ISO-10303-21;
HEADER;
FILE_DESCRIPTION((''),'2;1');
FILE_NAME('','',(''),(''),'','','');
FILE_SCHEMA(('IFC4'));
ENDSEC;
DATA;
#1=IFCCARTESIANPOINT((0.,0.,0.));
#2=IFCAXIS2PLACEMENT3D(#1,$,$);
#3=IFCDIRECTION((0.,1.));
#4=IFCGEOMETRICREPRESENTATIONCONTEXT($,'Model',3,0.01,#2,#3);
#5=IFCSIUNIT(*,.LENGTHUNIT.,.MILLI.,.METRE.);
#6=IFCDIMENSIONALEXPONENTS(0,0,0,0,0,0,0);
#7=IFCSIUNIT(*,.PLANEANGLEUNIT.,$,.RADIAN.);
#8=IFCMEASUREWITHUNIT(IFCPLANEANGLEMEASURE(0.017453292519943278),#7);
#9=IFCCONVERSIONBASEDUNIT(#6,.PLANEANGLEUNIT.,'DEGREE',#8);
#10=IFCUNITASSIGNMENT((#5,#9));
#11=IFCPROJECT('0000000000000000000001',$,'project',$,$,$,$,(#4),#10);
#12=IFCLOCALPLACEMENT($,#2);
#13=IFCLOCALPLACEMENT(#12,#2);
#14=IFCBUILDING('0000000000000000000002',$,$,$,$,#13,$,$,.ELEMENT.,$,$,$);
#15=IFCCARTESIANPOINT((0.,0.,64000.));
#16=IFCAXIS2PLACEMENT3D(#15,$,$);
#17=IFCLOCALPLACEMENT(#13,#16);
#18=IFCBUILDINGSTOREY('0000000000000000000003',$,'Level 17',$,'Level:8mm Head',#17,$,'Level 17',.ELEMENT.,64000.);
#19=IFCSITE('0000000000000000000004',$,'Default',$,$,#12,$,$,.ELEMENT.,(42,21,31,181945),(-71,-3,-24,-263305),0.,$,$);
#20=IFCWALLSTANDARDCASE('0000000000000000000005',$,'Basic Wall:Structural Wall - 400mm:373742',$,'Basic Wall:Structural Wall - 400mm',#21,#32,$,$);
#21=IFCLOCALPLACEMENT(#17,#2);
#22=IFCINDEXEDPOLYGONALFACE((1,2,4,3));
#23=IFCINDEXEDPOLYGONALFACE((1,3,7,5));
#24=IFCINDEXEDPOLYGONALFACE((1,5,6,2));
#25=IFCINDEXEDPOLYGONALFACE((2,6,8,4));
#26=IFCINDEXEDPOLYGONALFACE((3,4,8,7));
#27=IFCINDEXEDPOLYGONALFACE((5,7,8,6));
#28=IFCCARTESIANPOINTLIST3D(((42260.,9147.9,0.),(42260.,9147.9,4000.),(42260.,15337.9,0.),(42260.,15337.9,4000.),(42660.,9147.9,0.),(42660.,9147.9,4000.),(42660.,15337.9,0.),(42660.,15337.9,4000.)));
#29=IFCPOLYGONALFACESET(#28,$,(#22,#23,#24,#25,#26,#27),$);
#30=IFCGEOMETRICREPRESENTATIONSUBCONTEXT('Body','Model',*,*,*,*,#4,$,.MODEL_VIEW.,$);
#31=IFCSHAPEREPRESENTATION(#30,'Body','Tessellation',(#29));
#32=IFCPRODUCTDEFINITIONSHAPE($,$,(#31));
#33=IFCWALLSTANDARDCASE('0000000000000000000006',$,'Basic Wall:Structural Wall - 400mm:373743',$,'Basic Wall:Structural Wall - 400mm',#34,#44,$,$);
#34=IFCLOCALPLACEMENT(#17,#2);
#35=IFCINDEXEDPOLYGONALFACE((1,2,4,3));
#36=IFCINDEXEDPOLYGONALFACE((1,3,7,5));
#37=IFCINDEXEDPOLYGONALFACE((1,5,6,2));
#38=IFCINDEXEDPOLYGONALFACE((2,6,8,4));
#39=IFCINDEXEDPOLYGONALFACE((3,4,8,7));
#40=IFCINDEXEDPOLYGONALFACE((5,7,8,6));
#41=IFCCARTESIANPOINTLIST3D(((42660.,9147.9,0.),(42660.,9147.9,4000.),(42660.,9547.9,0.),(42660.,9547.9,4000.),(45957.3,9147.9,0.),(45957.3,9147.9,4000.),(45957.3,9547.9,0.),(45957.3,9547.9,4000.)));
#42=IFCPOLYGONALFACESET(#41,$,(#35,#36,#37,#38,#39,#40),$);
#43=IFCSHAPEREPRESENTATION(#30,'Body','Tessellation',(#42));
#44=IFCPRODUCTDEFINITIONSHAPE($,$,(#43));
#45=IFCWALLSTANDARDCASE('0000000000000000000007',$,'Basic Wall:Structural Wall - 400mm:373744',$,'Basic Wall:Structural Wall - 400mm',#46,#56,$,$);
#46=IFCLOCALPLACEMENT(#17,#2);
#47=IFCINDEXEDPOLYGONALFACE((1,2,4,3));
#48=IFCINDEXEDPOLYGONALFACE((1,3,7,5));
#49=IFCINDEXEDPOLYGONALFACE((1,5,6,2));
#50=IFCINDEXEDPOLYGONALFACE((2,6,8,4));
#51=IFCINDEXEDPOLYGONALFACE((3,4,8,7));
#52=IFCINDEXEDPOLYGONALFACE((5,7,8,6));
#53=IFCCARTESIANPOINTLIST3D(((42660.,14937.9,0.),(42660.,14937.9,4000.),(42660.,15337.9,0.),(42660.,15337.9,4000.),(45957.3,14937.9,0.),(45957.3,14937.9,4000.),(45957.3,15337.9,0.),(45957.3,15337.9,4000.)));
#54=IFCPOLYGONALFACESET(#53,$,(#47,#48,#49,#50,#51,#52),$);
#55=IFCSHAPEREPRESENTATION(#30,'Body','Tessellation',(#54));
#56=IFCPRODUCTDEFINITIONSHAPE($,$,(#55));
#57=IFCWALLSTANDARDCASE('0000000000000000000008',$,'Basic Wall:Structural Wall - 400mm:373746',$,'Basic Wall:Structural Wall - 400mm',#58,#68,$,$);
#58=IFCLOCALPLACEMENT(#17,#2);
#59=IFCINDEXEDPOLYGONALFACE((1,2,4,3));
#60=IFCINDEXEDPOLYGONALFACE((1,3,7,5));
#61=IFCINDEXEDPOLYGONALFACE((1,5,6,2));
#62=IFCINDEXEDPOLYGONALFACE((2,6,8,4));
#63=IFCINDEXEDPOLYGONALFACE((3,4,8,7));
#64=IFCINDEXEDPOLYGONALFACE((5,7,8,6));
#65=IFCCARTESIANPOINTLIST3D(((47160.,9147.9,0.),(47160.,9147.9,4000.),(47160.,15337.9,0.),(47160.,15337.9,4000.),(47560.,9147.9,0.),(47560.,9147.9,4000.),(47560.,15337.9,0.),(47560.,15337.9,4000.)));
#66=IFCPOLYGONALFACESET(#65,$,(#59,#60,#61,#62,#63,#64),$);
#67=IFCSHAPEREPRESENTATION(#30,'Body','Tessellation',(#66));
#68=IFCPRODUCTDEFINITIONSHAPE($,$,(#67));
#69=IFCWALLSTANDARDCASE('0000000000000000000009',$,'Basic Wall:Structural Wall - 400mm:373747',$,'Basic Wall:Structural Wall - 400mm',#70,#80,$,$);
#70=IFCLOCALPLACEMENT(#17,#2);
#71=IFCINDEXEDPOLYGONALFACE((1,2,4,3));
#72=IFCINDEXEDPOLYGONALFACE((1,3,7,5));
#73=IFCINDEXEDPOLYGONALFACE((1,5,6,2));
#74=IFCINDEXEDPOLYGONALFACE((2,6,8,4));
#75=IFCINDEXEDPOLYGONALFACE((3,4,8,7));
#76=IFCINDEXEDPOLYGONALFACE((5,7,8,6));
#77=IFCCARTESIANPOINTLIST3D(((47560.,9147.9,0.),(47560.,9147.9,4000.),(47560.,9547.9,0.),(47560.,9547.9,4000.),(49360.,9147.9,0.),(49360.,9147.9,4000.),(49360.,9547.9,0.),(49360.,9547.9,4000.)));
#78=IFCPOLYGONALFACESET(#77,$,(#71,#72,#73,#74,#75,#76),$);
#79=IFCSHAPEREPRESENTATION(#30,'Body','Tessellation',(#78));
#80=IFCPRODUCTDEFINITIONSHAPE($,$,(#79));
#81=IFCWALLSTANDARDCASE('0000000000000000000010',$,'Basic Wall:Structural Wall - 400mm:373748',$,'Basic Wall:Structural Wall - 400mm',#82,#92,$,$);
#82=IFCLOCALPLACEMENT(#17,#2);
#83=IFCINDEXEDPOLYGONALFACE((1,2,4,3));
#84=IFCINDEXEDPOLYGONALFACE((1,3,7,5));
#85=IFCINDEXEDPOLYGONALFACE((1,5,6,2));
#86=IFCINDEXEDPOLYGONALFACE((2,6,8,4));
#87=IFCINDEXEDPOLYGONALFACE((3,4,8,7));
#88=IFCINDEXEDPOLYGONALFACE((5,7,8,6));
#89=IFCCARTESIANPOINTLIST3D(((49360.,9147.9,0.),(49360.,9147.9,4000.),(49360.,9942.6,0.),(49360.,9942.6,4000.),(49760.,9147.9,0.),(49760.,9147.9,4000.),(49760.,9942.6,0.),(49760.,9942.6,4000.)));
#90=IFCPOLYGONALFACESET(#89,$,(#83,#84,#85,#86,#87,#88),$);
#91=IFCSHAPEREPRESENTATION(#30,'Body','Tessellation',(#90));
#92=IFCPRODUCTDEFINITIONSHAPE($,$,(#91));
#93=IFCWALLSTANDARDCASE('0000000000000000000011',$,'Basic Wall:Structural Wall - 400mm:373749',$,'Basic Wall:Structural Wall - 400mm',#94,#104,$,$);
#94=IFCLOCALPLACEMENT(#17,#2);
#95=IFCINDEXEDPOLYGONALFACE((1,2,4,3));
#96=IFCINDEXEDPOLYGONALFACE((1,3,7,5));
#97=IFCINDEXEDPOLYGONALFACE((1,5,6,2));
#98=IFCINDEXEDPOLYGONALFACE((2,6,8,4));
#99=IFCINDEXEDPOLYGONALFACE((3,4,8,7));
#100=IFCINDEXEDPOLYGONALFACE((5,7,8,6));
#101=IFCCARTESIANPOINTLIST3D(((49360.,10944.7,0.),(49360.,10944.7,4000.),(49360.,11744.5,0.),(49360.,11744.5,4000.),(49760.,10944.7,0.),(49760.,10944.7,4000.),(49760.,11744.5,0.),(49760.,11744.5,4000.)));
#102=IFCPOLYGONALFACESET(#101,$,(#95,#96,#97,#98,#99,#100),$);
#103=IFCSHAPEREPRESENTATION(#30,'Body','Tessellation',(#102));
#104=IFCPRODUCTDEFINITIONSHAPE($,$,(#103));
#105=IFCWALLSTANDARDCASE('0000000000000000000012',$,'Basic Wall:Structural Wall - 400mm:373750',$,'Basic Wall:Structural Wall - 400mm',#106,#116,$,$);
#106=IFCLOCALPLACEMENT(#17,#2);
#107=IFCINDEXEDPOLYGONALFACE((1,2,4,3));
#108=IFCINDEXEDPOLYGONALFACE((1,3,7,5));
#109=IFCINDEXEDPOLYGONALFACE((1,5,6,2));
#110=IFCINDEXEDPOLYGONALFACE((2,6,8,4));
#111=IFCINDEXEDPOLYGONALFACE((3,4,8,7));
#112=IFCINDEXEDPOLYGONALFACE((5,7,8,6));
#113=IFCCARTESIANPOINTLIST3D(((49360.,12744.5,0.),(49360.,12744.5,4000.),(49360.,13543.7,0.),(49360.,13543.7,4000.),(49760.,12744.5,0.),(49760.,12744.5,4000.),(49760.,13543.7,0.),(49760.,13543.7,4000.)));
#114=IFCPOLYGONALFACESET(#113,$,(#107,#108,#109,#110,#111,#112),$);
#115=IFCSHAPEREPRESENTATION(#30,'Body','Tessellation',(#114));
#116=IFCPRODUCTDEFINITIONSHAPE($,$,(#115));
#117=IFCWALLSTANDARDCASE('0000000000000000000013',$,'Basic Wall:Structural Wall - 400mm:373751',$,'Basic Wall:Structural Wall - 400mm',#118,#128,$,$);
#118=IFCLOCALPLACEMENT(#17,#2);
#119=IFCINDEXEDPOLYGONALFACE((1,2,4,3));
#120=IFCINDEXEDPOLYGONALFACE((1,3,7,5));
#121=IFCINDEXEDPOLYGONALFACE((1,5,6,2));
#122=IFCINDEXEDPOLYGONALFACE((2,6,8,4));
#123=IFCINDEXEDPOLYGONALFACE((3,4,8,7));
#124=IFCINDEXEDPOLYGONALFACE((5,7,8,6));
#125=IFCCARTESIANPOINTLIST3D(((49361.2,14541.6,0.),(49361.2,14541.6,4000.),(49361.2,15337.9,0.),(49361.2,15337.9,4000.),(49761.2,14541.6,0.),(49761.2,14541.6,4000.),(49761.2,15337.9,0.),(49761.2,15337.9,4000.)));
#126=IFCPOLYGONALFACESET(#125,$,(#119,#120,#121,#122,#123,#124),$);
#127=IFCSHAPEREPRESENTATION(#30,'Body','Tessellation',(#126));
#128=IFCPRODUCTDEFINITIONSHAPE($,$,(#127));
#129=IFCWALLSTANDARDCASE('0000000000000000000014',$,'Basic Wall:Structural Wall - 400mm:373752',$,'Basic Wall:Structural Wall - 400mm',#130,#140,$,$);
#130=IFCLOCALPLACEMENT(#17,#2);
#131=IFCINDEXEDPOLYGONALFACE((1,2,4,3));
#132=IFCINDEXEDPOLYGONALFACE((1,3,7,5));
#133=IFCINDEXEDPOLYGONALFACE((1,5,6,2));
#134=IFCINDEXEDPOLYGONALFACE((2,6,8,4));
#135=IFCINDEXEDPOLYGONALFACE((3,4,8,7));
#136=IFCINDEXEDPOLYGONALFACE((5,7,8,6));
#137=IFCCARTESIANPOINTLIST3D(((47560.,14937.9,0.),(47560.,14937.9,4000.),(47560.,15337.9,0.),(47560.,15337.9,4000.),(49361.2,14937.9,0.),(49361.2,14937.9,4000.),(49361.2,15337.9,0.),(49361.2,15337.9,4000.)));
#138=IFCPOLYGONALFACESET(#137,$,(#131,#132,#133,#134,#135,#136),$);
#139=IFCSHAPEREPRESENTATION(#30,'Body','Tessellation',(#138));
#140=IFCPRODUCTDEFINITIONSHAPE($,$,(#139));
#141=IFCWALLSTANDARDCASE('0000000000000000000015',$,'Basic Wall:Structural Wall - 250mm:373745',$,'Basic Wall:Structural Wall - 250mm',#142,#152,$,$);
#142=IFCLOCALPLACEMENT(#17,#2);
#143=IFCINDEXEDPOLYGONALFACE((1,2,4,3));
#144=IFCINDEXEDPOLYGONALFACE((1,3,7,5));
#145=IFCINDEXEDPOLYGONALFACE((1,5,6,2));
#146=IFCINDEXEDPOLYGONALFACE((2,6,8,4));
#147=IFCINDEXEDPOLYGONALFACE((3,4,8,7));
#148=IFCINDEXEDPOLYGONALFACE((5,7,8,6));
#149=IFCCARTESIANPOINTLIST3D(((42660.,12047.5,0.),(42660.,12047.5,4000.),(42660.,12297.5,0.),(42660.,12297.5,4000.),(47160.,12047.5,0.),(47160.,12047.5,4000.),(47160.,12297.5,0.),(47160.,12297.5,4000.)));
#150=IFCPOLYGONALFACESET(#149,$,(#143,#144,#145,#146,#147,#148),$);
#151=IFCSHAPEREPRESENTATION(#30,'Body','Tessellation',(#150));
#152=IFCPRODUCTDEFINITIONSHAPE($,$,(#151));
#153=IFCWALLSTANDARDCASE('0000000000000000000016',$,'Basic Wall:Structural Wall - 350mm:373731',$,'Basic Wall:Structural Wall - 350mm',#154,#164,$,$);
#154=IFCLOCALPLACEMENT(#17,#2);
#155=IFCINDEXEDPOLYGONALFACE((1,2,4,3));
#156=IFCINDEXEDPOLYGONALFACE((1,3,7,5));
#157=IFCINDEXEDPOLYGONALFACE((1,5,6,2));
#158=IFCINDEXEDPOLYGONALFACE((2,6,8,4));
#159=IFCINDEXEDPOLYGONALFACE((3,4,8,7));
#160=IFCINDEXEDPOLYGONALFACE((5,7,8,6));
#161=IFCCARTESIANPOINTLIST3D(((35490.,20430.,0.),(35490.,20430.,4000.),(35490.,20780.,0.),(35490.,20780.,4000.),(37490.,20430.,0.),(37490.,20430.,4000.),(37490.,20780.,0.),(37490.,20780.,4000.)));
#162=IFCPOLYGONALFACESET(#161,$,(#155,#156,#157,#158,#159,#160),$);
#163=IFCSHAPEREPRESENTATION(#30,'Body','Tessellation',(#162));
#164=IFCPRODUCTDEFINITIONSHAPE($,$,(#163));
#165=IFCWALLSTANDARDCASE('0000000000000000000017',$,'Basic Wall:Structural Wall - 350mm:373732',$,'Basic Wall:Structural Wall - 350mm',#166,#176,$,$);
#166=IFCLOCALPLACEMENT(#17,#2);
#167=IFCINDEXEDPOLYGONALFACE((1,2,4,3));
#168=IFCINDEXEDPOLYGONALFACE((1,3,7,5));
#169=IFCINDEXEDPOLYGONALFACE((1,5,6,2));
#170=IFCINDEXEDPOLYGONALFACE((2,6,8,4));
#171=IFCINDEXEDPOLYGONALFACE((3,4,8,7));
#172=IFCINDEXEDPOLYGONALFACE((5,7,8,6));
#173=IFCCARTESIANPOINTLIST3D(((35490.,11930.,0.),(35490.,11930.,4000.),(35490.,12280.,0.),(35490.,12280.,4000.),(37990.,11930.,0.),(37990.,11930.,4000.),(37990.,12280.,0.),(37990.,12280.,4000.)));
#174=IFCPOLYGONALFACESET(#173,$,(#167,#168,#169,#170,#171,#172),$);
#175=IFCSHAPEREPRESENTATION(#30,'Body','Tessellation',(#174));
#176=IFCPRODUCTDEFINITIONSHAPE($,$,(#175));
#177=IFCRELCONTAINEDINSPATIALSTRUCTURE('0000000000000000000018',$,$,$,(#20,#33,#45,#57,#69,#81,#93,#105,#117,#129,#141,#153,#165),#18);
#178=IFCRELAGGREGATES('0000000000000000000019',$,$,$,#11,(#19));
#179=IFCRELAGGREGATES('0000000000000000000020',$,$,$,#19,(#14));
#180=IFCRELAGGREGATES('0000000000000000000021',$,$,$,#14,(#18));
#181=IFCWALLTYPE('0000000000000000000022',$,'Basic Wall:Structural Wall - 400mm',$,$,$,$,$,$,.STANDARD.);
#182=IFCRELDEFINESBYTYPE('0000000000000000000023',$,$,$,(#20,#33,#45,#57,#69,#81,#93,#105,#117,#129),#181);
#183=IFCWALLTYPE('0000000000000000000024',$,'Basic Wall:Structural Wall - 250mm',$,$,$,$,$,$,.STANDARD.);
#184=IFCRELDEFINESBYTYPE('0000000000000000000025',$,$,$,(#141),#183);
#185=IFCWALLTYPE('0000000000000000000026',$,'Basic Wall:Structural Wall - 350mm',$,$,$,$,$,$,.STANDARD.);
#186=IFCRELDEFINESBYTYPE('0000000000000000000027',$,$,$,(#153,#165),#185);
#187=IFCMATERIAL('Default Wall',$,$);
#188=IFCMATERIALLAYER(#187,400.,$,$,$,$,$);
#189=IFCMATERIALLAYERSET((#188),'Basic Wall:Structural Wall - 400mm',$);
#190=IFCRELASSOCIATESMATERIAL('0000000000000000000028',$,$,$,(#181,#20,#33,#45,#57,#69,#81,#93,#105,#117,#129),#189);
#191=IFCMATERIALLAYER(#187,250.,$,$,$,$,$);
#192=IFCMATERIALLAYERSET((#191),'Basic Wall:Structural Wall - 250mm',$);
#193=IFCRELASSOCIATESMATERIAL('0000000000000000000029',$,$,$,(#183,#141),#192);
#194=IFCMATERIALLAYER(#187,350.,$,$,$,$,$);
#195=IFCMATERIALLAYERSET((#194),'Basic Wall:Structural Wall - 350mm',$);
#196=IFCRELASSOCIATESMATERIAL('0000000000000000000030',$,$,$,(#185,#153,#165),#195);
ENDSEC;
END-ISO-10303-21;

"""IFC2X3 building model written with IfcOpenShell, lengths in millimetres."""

from ifc_helpers import new_model, entity, si_unit, converted_unit, direction, frame, frame_2d, origin, place, context, subcontext, project, spatial, rectangle, extrude, material, layer, layer_set, layer_usage, type_object, element, save


model = new_model("IFC2X3")

# Units and contexts
model_context = context("Model", 3, precision=0.01, world=origin(), true_north=direction((0.0, 1.0)))
body_context = subcontext(model_context, "Body", "Model", "MODEL_VIEW")
ifc_project = project(units=[si_unit("LENGTHUNIT", "METRE", prefix="MILLI"), converted_unit("PLANEANGLEUNIT", "DEGREE", entity("IfcPlaneAngleMeasure", 0.017453292519943278), si_unit("PLANEANGLEUNIT", "RADIAN"), dimensions=[0, 0, 0, 0, 0, 0, 0])], contexts=[model_context])

# Site, building, storey
site_placement = place(None, origin())
site = spatial("IfcSite", under=ifc_project, at=site_placement, Name="Default", CompositionType="ELEMENT", RefLatitude=(42, 21, 31, 181945), RefLongitude=(-71, -3, -24, -263305), RefElevation=0.0)
building_placement = place(site_placement, origin())
building = spatial("IfcBuilding", under=site, at=building_placement, CompositionType="ELEMENT")
storey_placement = place(building_placement, frame((0.0, 0.0, 64000.0)))
storey = spatial("IfcBuildingStorey", under=building, at=storey_placement, Name="Level 17", ObjectType="Level:8mm Head", LongName="Level 17", CompositionType="ELEMENT", Elevation=64000.0)

# Walls
ifc_material_1 = material(Name="Default Wall")
ifc_layer_1 = layer(ifc_material_1, 400.0)
ifc_layer_set_1 = layer_set([ifc_layer_1], Name="Basic Wall:Structural Wall - 400mm")
ifc_layer_usage_1 = layer_usage(ifc_layer_set_1, "AXIS2", "POSITIVE", -200.0)
wall_type_1 = type_object("IfcWallType", Name="Basic Wall:Structural Wall - 400mm", PredefinedType="STANDARD", material=ifc_layer_set_1)
wall_1_placement = place(storey_placement, frame((42460.0, 15337.9, 0.0), z_axis=(0.0, 0.0, 1.0), x_axis=(0.0, -1.0, 0.0)))
element("IfcWallStandardCase", 1, at=wall_1_placement, inside=storey, type_object=wall_type_1, material=ifc_layer_usage_1, Name="Basic Wall:Structural Wall - 400mm:373742", ObjectType="Basic Wall:Structural Wall - 400mm", context=body_context, shape_type="SweptSolid", body=[
    extrude(rectangle(XDim=6190.0, YDim=400.0, at=frame_2d((3095.0, 0.0), x_axis=(-1.0, 0.0))), origin(), (0.0, 0.0, 1.0), 4000.0),
])
ifc_layer_usage_2 = layer_usage(ifc_layer_set_1, "AXIS2", "POSITIVE", -200.0)
wall_2_placement = place(storey_placement, frame((42660.0, 9347.9, 0.0)))
element("IfcWallStandardCase", 2, at=wall_2_placement, inside=storey, type_object=wall_type_1, material=ifc_layer_usage_2, Name="Basic Wall:Structural Wall - 400mm:373743", ObjectType="Basic Wall:Structural Wall - 400mm", context=body_context, shape_type="SweptSolid", body=[
    extrude(rectangle(XDim=3297.3, YDim=400.0, at=frame_2d((1648.6, 0.0), x_axis=(-1.0, 0.0))), origin(), (0.0, 0.0, 1.0), 4000.0),
])
ifc_layer_usage_3 = layer_usage(ifc_layer_set_1, "AXIS2", "POSITIVE", -200.0)
wall_3_placement = place(storey_placement, frame((45957.3, 15137.9, 0.0), z_axis=(0.0, 0.0, 1.0), x_axis=(-1.0, 0.0, 0.0)))
element("IfcWallStandardCase", 3, at=wall_3_placement, inside=storey, type_object=wall_type_1, material=ifc_layer_usage_3, Name="Basic Wall:Structural Wall - 400mm:373744", ObjectType="Basic Wall:Structural Wall - 400mm", context=body_context, shape_type="SweptSolid", body=[
    extrude(rectangle(XDim=3297.3, YDim=400.0, at=frame_2d((1648.6, 0.0), x_axis=(-1.0, 0.0))), origin(), (0.0, 0.0, 1.0), 4000.0),
])
ifc_layer_usage_4 = layer_usage(ifc_layer_set_1, "AXIS2", "POSITIVE", -200.0)
wall_4_placement = place(storey_placement, frame((47360.0, 15337.9, 0.0), z_axis=(0.0, 0.0, 1.0), x_axis=(0.0, -1.0, 0.0)))
element("IfcWallStandardCase", 4, at=wall_4_placement, inside=storey, type_object=wall_type_1, material=ifc_layer_usage_4, Name="Basic Wall:Structural Wall - 400mm:373746", ObjectType="Basic Wall:Structural Wall - 400mm", context=body_context, shape_type="SweptSolid", body=[
    extrude(rectangle(XDim=6190.0, YDim=400.0, at=frame_2d((3095.0, 0.0), x_axis=(-1.0, 0.0))), origin(), (0.0, 0.0, 1.0), 4000.0),
])
ifc_layer_usage_5 = layer_usage(ifc_layer_set_1, "AXIS2", "POSITIVE", -200.0)
wall_5_placement = place(storey_placement, frame((47560.0, 9347.9, 0.0)))
element("IfcWallStandardCase", 5, at=wall_5_placement, inside=storey, type_object=wall_type_1, material=ifc_layer_usage_5, Name="Basic Wall:Structural Wall - 400mm:373747", ObjectType="Basic Wall:Structural Wall - 400mm", context=body_context, shape_type="SweptSolid", body=[
    extrude(rectangle(XDim=1800.0, YDim=400.0, at=frame_2d((900.0, 0.0), x_axis=(-1.0, 0.0))), origin(), (0.0, 0.0, 1.0), 4000.0),
])
ifc_layer_usage_6 = layer_usage(ifc_layer_set_1, "AXIS2", "NEGATIVE", 200.0)
wall_6_placement = place(storey_placement, frame((49560.0, 9147.9, 0.0), z_axis=(0.0, 0.0, 1.0), x_axis=(0.0, 1.0, 0.0)))
element("IfcWallStandardCase", 6, at=wall_6_placement, inside=storey, type_object=wall_type_1, material=ifc_layer_usage_6, Name="Basic Wall:Structural Wall - 400mm:373748", ObjectType="Basic Wall:Structural Wall - 400mm", context=body_context, shape_type="SweptSolid", body=[
    extrude(rectangle(XDim=794.7, YDim=400.0, at=frame_2d((397.3, 0.0), x_axis=(-1.0, 0.0))), origin(), (0.0, 0.0, 1.0), 4000.0),
])
ifc_layer_usage_7 = layer_usage(ifc_layer_set_1, "AXIS2", "POSITIVE", -200.0)
wall_7_placement = place(storey_placement, frame((49560.0, 10944.7, 0.0), z_axis=(0.0, 0.0, 1.0), x_axis=(0.0, 1.0, 0.0)))
element("IfcWallStandardCase", 7, at=wall_7_placement, inside=storey, type_object=wall_type_1, material=ifc_layer_usage_7, Name="Basic Wall:Structural Wall - 400mm:373749", ObjectType="Basic Wall:Structural Wall - 400mm", context=body_context, shape_type="SweptSolid", body=[
    extrude(rectangle(XDim=799.8, YDim=400.0, at=frame_2d((399.9, 0.0), x_axis=(-1.0, 0.0))), origin(), (0.0, 0.0, 1.0), 4000.0),
])
ifc_layer_usage_8 = layer_usage(ifc_layer_set_1, "AXIS2", "POSITIVE", -200.0)
wall_8_placement = place(storey_placement, frame((49560.0, 12744.5, 0.0), z_axis=(0.0, 0.0, 1.0), x_axis=(0.0, 1.0, 0.0)))
element("IfcWallStandardCase", 8, at=wall_8_placement, inside=storey, type_object=wall_type_1, material=ifc_layer_usage_8, Name="Basic Wall:Structural Wall - 400mm:373750", ObjectType="Basic Wall:Structural Wall - 400mm", context=body_context, shape_type="SweptSolid", body=[
    extrude(rectangle(XDim=799.2, YDim=400.0, at=frame_2d((399.6, 0.0), x_axis=(-1.0, 0.0))), origin(), (0.0, 0.0, 1.0), 4000.0),
])
ifc_layer_usage_9 = layer_usage(ifc_layer_set_1, "AXIS2", "POSITIVE", -200.0)
wall_9_placement = place(storey_placement, frame((49561.2, 14541.6, 0.0), z_axis=(0.0, 0.0, 1.0), x_axis=(0.0, 1.0, 0.0)))
element("IfcWallStandardCase", 9, at=wall_9_placement, inside=storey, type_object=wall_type_1, material=ifc_layer_usage_9, Name="Basic Wall:Structural Wall - 400mm:373751", ObjectType="Basic Wall:Structural Wall - 400mm", context=body_context, shape_type="SweptSolid", body=[
    extrude(rectangle(XDim=796.3, YDim=400.0, at=frame_2d((398.2, 0.0), x_axis=(-1.0, 0.0))), origin(), (0.0, 0.0, 1.0), 4000.0),
])
ifc_layer_usage_10 = layer_usage(ifc_layer_set_1, "AXIS2", "POSITIVE", -200.0)
wall_10_placement = place(storey_placement, frame((49361.2, 15137.9, 0.0), z_axis=(0.0, 0.0, 1.0), x_axis=(-1.0, 0.0, 0.0)))
element("IfcWallStandardCase", 10, at=wall_10_placement, inside=storey, type_object=wall_type_1, material=ifc_layer_usage_10, Name="Basic Wall:Structural Wall - 400mm:373752", ObjectType="Basic Wall:Structural Wall - 400mm", context=body_context, shape_type="SweptSolid", body=[
    extrude(rectangle(XDim=1801.2, YDim=400.0, at=frame_2d((900.6, 0.0), x_axis=(-1.0, 0.0))), origin(), (0.0, 0.0, 1.0), 4000.0),
])
ifc_layer_2 = layer(ifc_material_1, 250.0)
ifc_layer_set_2 = layer_set([ifc_layer_2], Name="Basic Wall:Structural Wall - 250mm")
ifc_layer_usage_11 = layer_usage(ifc_layer_set_2, "AXIS2", "NEGATIVE", 125.0)
wall_type_2 = type_object("IfcWallType", Name="Basic Wall:Structural Wall - 250mm", PredefinedType="STANDARD", material=ifc_layer_set_2)
wall_11_placement = place(storey_placement, frame((42660.0, 12172.5, 0.0)))
element("IfcWallStandardCase", 11, at=wall_11_placement, inside=storey, type_object=wall_type_2, material=ifc_layer_usage_11, Name="Basic Wall:Structural Wall - 250mm:373745", ObjectType="Basic Wall:Structural Wall - 250mm", context=body_context, shape_type="SweptSolid", body=[
    extrude(rectangle(XDim=4500.0, YDim=250.0, at=frame_2d((2250.0, 0.0), x_axis=(-1.0, 0.0))), origin(), (0.0, 0.0, 1.0), 4000.0),
])
ifc_layer_3 = layer(ifc_material_1, 350.0)
ifc_layer_set_3 = layer_set([ifc_layer_3], Name="Basic Wall:Structural Wall - 350mm")
ifc_layer_usage_12 = layer_usage(ifc_layer_set_3, "AXIS2", "NEGATIVE", 175.0)
wall_type_3 = type_object("IfcWallType", Name="Basic Wall:Structural Wall - 350mm", PredefinedType="STANDARD", material=ifc_layer_set_3)
wall_12_placement = place(storey_placement, frame((35490.0, 20605.0, 0.0)))
element("IfcWallStandardCase", 12, at=wall_12_placement, inside=storey, type_object=wall_type_3, material=ifc_layer_usage_12, Name="Basic Wall:Structural Wall - 350mm:373731", ObjectType="Basic Wall:Structural Wall - 350mm", context=body_context, shape_type="SweptSolid", body=[
    extrude(rectangle(XDim=2000.0, YDim=350.0, at=frame_2d((1000.0, 0.0), x_axis=(-1.0, 0.0))), origin(), (0.0, 0.0, 1.0), 4000.0),
])
ifc_layer_usage_13 = layer_usage(ifc_layer_set_3, "AXIS2", "POSITIVE", -175.0)
wall_13_placement = place(storey_placement, frame((35490.0, 12105.0, 0.0)))
element("IfcWallStandardCase", 13, at=wall_13_placement, inside=storey, type_object=wall_type_3, material=ifc_layer_usage_13, Name="Basic Wall:Structural Wall - 350mm:373732", ObjectType="Basic Wall:Structural Wall - 350mm", context=body_context, shape_type="SweptSolid", body=[
    extrude(rectangle(XDim=2500.0, YDim=350.0, at=frame_2d((1250.0, 0.0), x_axis=(-1.0, 0.0))), origin(), (0.0, 0.0, 1.0), 4000.0),
])

save(model, "model.ifc")
